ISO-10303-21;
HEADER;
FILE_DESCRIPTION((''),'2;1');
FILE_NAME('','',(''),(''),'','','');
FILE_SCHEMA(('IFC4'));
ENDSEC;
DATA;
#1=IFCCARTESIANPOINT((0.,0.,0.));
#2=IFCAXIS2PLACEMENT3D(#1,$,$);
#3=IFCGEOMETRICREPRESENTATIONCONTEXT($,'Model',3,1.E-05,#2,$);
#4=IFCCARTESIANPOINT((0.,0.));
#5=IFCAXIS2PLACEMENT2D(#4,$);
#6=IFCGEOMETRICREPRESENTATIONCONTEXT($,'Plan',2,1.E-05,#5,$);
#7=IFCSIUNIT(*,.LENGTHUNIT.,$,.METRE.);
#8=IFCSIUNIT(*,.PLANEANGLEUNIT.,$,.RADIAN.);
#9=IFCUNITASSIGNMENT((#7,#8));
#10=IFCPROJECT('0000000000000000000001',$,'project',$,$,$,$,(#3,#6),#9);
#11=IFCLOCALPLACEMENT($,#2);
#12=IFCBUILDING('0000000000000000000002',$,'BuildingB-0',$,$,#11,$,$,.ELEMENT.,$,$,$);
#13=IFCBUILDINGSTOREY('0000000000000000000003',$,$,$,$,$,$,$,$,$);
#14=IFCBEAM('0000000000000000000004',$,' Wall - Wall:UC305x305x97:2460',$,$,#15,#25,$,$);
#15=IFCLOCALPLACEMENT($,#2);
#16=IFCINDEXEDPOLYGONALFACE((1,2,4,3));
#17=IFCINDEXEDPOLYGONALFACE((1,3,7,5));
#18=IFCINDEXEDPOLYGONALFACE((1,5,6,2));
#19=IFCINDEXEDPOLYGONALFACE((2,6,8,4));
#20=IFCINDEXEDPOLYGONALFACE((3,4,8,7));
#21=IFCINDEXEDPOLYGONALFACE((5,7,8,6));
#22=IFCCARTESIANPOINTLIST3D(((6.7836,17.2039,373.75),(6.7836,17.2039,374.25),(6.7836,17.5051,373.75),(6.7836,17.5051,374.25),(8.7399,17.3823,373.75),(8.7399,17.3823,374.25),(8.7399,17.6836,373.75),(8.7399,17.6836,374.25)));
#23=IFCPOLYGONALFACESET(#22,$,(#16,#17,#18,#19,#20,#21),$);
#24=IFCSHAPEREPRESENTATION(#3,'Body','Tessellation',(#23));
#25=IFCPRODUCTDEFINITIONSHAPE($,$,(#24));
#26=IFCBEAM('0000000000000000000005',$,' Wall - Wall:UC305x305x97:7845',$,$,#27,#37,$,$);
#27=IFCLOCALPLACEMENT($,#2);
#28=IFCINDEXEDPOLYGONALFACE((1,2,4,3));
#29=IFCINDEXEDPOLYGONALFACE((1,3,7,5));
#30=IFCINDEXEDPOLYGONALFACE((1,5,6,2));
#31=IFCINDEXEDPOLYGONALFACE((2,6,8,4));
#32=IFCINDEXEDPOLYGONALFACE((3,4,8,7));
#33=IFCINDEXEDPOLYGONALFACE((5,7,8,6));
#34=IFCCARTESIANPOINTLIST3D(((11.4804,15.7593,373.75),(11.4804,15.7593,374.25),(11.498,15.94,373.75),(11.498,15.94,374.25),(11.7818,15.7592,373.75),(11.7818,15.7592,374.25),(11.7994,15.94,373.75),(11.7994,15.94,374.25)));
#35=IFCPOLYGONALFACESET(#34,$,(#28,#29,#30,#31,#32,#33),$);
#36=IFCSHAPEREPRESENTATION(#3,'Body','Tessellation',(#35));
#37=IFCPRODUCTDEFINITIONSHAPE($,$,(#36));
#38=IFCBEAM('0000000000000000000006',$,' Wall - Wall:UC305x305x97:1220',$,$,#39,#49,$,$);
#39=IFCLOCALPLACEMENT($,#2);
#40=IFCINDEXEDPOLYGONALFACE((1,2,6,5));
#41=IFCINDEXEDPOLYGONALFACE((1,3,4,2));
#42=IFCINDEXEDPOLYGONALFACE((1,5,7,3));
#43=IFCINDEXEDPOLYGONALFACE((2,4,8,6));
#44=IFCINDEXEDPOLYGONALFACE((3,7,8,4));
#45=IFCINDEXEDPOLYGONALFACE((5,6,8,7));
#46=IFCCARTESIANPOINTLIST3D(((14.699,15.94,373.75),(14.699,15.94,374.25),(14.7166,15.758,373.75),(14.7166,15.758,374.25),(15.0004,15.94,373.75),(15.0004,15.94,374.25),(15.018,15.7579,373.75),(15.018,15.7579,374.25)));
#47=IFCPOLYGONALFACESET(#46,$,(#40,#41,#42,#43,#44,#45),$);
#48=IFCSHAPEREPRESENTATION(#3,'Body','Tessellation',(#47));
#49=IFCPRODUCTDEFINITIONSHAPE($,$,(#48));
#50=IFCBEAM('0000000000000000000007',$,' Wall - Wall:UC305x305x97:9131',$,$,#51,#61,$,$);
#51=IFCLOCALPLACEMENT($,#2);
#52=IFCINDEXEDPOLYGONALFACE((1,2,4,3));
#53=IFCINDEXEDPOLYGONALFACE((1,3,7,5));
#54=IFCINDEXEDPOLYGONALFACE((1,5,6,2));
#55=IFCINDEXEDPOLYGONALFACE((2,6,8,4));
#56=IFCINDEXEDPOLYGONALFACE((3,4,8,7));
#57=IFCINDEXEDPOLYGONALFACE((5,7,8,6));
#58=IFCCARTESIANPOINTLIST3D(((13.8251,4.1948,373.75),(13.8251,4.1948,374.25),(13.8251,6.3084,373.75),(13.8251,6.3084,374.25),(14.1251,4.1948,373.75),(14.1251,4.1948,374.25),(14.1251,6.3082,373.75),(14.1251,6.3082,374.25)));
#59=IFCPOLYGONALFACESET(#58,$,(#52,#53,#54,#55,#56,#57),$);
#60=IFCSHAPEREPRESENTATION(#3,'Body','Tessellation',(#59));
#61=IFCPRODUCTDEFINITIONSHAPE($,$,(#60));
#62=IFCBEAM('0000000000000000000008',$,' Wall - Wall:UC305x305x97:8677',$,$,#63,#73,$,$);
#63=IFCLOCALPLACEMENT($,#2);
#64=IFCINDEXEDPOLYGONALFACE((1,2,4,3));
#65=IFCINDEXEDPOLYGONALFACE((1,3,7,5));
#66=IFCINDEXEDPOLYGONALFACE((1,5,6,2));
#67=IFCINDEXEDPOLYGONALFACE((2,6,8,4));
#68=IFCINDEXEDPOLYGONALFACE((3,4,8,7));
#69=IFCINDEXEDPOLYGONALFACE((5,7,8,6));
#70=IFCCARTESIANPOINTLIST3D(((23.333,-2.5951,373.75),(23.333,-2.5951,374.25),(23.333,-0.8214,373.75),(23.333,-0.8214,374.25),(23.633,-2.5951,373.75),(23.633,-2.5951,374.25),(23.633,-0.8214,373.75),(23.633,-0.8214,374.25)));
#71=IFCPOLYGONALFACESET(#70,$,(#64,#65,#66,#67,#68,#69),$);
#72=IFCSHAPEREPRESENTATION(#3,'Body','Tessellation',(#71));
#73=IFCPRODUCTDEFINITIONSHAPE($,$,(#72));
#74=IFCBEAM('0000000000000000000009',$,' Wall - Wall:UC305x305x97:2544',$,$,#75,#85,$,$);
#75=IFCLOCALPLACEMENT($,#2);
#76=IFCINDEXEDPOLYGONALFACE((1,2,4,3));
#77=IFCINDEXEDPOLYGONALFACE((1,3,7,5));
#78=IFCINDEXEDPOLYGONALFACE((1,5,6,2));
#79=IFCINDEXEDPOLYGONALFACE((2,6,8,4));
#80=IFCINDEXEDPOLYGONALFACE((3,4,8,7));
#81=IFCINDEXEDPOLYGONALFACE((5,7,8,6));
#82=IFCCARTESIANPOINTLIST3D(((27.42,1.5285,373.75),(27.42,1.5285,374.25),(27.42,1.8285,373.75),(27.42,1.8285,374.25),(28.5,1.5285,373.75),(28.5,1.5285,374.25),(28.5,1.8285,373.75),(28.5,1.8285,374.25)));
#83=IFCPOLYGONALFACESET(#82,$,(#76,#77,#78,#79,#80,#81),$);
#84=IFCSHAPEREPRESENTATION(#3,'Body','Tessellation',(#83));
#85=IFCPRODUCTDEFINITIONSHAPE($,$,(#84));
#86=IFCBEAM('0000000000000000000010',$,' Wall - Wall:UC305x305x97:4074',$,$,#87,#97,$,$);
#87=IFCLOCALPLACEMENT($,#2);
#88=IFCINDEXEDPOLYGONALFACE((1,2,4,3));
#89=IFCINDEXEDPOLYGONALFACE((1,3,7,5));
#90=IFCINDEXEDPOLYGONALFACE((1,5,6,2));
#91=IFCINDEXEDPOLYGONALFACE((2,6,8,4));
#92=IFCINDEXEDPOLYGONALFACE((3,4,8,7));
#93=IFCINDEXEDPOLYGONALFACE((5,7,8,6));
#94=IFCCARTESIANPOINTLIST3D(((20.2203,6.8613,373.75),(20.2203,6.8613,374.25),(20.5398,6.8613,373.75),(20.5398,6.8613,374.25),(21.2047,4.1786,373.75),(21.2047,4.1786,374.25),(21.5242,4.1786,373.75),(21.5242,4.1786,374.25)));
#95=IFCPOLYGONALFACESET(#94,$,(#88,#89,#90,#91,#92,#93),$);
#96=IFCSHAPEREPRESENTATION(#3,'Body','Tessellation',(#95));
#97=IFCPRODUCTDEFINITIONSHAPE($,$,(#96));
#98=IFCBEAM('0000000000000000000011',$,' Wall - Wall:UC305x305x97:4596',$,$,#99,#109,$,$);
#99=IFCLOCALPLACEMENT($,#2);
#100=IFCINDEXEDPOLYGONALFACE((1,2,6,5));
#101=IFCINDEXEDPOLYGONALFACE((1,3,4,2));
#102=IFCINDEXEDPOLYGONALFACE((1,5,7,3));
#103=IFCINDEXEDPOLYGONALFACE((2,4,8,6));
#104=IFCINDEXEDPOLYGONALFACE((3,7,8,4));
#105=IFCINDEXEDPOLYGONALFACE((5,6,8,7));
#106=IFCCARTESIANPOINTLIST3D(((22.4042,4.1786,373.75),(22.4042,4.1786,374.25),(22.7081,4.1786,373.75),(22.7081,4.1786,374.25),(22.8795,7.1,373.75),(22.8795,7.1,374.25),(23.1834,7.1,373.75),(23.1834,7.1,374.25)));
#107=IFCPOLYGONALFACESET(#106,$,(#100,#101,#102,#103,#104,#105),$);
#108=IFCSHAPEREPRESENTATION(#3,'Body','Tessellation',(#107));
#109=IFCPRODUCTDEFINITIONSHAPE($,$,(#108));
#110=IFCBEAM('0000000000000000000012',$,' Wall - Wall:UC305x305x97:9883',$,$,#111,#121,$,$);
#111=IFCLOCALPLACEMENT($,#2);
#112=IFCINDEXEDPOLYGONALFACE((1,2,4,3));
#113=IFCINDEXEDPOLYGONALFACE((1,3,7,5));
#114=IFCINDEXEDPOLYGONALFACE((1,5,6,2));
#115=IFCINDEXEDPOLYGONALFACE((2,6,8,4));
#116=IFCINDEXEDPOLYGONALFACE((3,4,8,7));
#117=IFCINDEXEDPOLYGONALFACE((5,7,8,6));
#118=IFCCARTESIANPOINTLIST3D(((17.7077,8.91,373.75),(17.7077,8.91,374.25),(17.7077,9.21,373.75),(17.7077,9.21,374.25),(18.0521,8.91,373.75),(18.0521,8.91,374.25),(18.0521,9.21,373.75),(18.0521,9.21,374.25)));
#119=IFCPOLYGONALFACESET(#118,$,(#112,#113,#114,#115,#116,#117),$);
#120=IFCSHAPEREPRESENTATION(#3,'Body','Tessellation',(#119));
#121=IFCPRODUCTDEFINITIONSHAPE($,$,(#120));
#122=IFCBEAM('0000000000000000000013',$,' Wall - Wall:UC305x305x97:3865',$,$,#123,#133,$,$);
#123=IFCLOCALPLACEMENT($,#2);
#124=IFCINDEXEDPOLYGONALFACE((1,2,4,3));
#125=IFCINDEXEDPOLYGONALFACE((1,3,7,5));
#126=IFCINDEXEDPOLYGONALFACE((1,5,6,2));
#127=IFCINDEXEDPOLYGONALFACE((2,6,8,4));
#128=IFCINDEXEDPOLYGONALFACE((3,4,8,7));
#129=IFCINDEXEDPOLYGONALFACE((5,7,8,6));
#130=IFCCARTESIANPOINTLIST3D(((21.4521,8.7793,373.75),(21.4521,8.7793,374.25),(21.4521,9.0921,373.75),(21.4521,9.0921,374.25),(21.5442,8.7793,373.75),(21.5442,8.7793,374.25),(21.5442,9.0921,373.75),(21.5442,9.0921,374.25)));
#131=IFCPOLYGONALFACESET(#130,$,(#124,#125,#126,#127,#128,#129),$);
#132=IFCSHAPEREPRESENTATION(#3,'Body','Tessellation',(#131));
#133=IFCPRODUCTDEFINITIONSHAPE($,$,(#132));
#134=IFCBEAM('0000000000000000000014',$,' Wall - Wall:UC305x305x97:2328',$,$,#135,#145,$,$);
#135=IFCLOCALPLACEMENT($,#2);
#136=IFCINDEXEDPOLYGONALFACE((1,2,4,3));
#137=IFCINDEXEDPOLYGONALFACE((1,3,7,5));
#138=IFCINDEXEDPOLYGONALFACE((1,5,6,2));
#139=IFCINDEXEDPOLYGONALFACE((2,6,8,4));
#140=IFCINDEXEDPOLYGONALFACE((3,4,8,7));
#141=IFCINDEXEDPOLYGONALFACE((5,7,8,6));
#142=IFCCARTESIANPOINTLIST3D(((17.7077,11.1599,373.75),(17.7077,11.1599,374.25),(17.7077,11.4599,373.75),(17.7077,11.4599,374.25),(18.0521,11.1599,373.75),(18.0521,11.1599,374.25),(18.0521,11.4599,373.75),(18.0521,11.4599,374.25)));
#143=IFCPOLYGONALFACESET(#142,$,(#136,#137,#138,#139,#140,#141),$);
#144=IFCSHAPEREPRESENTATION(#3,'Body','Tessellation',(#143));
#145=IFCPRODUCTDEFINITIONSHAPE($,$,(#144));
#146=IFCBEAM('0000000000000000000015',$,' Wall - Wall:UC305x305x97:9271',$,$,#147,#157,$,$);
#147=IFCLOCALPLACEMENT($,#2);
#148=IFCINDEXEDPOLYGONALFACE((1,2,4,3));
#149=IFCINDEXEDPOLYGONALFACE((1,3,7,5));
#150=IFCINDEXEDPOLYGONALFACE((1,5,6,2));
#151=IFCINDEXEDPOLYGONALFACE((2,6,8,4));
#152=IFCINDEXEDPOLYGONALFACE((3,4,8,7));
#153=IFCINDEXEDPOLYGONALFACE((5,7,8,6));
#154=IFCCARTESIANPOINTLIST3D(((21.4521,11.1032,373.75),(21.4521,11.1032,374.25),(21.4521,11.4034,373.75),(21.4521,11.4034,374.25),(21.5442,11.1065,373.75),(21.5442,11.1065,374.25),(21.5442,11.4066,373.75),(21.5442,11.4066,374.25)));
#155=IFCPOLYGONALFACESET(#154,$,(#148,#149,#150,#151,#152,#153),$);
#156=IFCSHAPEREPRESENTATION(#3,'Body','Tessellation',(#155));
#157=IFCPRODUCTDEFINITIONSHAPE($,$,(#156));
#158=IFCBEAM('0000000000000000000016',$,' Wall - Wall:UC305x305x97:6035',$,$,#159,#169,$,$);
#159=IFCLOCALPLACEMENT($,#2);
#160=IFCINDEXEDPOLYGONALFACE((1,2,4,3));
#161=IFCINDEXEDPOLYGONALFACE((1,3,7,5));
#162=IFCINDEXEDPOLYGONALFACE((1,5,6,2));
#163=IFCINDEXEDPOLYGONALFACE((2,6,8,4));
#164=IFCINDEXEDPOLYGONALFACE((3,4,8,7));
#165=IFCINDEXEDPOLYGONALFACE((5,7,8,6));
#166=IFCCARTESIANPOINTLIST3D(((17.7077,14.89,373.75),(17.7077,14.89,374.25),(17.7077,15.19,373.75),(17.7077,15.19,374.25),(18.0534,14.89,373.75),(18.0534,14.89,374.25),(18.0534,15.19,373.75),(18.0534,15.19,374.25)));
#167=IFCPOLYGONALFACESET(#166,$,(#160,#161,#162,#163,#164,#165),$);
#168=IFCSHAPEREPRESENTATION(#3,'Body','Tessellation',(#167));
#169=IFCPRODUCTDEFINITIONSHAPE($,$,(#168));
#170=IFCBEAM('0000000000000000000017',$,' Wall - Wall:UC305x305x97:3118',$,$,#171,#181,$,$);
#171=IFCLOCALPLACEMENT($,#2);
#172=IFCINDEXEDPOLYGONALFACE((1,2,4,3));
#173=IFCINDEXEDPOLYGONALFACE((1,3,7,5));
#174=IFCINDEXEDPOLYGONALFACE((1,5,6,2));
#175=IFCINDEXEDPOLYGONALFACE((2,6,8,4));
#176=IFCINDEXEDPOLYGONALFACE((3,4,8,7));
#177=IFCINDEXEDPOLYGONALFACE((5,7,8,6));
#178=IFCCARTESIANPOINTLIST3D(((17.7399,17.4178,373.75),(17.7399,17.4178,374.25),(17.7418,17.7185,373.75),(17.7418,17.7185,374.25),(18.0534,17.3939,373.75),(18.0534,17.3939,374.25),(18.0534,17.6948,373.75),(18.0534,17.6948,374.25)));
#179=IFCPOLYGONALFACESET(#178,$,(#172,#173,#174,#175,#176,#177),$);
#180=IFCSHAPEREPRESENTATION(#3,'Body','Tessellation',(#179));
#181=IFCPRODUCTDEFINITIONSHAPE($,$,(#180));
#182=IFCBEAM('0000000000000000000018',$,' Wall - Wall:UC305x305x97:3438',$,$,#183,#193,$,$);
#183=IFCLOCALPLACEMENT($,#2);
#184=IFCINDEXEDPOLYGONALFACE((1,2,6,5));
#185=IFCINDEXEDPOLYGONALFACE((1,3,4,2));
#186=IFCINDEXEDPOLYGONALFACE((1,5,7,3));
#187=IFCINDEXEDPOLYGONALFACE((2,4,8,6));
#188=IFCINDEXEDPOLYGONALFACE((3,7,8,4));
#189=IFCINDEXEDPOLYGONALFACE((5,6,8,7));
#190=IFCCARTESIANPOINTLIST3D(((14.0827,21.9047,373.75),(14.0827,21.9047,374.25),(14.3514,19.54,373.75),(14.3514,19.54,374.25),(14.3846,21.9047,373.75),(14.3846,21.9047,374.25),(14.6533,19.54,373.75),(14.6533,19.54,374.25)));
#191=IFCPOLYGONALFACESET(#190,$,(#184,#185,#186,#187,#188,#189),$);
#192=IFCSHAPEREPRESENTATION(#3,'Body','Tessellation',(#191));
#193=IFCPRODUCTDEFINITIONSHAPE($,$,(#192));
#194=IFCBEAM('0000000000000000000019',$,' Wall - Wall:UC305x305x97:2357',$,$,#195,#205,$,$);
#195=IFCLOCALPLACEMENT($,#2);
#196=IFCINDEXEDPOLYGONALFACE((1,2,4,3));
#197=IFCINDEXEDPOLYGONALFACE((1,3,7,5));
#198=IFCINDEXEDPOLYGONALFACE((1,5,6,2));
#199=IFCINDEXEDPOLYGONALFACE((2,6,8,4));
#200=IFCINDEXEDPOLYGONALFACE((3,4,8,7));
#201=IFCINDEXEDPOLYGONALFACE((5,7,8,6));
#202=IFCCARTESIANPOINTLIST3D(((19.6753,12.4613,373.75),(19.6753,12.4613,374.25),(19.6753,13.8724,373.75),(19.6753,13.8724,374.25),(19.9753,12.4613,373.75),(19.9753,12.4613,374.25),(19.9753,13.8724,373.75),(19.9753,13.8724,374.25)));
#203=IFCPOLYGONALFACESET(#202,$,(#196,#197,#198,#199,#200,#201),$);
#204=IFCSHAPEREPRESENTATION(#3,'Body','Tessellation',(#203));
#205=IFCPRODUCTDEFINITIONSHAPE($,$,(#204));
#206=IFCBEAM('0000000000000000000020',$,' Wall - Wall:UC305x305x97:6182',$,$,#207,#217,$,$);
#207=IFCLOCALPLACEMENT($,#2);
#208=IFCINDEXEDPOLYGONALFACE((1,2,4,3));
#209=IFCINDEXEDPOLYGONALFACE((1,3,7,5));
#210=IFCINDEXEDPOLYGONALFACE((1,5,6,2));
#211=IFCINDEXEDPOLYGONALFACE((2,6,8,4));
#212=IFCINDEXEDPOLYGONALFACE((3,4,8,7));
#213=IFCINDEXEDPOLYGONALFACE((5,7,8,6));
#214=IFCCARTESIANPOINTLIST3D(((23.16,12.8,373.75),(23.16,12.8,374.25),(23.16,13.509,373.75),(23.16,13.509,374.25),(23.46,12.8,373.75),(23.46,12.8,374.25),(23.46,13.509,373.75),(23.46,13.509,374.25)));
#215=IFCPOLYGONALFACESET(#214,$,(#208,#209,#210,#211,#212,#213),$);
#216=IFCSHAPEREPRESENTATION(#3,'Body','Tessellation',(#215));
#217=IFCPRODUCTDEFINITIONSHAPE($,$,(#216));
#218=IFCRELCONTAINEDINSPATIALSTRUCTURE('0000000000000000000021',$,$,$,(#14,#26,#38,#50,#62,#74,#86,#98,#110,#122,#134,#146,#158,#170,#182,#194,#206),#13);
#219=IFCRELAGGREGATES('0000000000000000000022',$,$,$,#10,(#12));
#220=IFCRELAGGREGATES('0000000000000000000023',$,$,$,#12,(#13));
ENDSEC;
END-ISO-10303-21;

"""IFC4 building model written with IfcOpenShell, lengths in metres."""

from ifc_helpers import new_model, si_unit, origin, origin_2d, place, context, project, spatial, polyline, outline, extrude, element, save


model = new_model("IFC4")

# Units and contexts
model_context = context("Model", 3, precision=1e-05, world=origin())
plan_context = context("Plan", 2, precision=1e-05, world=origin_2d())
ifc_project = project(units=[si_unit("LENGTHUNIT", "METRE"), si_unit("PLANEANGLEUNIT", "RADIAN")], contexts=[model_context, plan_context])

# Building, storey
building_placement = place(None, origin())
building = spatial("IfcBuilding", under=ifc_project, at=building_placement, Name="BuildingB-0", CompositionType="ELEMENT")
storey = spatial("IfcBuildingStorey", under=building)

# Beams
element("IfcBeam", 1, inside=storey, Name=" Wall - Wall:UC305x305x97:2460", context=model_context, shape_type="SweptSolid", body=[
    extrude(outline(polyline([(6.7836, 17.2039, 373.75), (6.7836, 17.5051, 373.75), (8.7399, 17.6836, 373.75), (8.7399, 17.3823, 373.75), (6.7836, 17.2039, 373.75)])), None, (0.0, 0.0, 1.0), 0.5),
])
element("IfcBeam", 2, inside=storey, Name=" Wall - Wall:UC305x305x97:7845", context=model_context, shape_type="SweptSolid", body=[
    extrude(outline(polyline([(11.4804, 15.7593, 373.75), (11.498, 15.94, 373.75), (11.7994, 15.94, 373.75), (11.7818, 15.7592, 373.75), (11.4804, 15.7593, 373.75)])), None, (0.0, 0.0, 1.0), 0.5),
])
element("IfcBeam", 3, inside=storey, Name=" Wall - Wall:UC305x305x97:1220", context=model_context, shape_type="SweptSolid", body=[
    extrude(outline(polyline([(14.7166, 15.758, 373.75), (14.699, 15.94, 373.75), (15.0004, 15.94, 373.75), (15.018, 15.7579, 373.75), (14.7166, 15.758, 373.75)])), None, (0.0, 0.0, 1.0), 0.5),
])
element("IfcBeam", 4, inside=storey, Name=" Wall - Wall:UC305x305x97:9131", context=model_context, shape_type="SweptSolid", body=[
    extrude(outline(polyline([(13.8251, 4.1948, 373.75), (13.8251, 6.3084, 373.75), (14.1251, 6.3082, 373.75), (14.1251, 4.1948, 373.75), (13.8251, 4.1948, 373.75)])), None, (0.0, 0.0, 1.0), 0.5),
])
element("IfcBeam", 5, inside=storey, Name=" Wall - Wall:UC305x305x97:8677", context=model_context, shape_type="SweptSolid", body=[
    extrude(outline(polyline([(23.333, -2.5951, 373.75), (23.333, -0.8214, 373.75), (23.633, -0.8214, 373.75), (23.633, -2.5951, 373.75), (23.333, -2.5951, 373.75)])), None, (0.0, 0.0, 1.0), 0.5),
])
element("IfcBeam", 6, inside=storey, Name=" Wall - Wall:UC305x305x97:2544", context=model_context, shape_type="SweptSolid", body=[
    extrude(outline(polyline([(27.42, 1.5285, 373.75), (27.42, 1.8285, 373.75), (28.5, 1.8285, 373.75), (28.5, 1.5285, 373.75), (27.42, 1.5285, 373.75)])), None, (0.0, 0.0, 1.0), 0.5),
])
element("IfcBeam", 7, inside=storey, Name=" Wall - Wall:UC305x305x97:4074", context=model_context, shape_type="SweptSolid", body=[
    extrude(outline(polyline([(21.2047, 4.1786, 373.75), (21.5242, 4.1786, 373.75), (20.5398, 6.8613, 373.75), (20.2203, 6.8613, 373.75), (21.2047, 4.1786, 373.75)])), None, (0.0, 0.0, 1.0), 0.5),
])
element("IfcBeam", 8, inside=storey, Name=" Wall - Wall:UC305x305x97:4596", context=model_context, shape_type="SweptSolid", body=[
    extrude(outline(polyline([(22.4042, 4.1786, 373.75), (22.7081, 4.1786, 373.75), (23.1834, 7.1, 373.75), (22.8795, 7.1, 373.75), (22.4042, 4.1786, 373.75)])), None, (0.0, 0.0, 1.0), 0.5),
])
element("IfcBeam", 9, inside=storey, Name=" Wall - Wall:UC305x305x97:9883", context=model_context, shape_type="SweptSolid", body=[
    extrude(outline(polyline([(17.7077, 8.91, 373.75), (17.7077, 9.21, 373.75), (18.0521, 9.21, 373.75), (18.0521, 8.91, 373.75), (17.7077, 8.91, 373.75)])), None, (0.0, 0.0, 1.0), 0.5),
])
element("IfcBeam", 10, inside=storey, Name=" Wall - Wall:UC305x305x97:3865", context=model_context, shape_type="SweptSolid", body=[
    extrude(outline(polyline([(21.4521, 8.7793, 373.75), (21.5442, 8.7793, 373.75), (21.5442, 9.0921, 373.75), (21.4521, 9.0921, 373.75), (21.4521, 8.7793, 373.75)])), None, (0.0, 0.0, 1.0), 0.5),
])
element("IfcBeam", 11, inside=storey, Name=" Wall - Wall:UC305x305x97:2328", context=model_context, shape_type="SweptSolid", body=[
    extrude(outline(polyline([(17.7077, 11.1599, 373.75), (18.0521, 11.1599, 373.75), (18.0521, 11.4599, 373.75), (17.7077, 11.4599, 373.75), (17.7077, 11.1599, 373.75)])), None, (0.0, 0.0, 1.0), 0.5),
])
element("IfcBeam", 12, inside=storey, Name=" Wall - Wall:UC305x305x97:9271", context=model_context, shape_type="SweptSolid", body=[
    extrude(outline(polyline([(21.4521, 11.1032, 373.75), (21.5442, 11.1065, 373.75), (21.5442, 11.4066, 373.75), (21.4521, 11.4034, 373.75), (21.4521, 11.1032, 373.75)])), None, (0.0, 0.0, 1.0), 0.5),
])
element("IfcBeam", 13, inside=storey, Name=" Wall - Wall:UC305x305x97:6035", context=model_context, shape_type="SweptSolid", body=[
    extrude(outline(polyline([(17.7077, 15.19, 373.75), (18.0534, 15.19, 373.75), (18.0534, 14.89, 373.75), (17.7077, 14.89, 373.75), (17.7077, 15.19, 373.75)])), None, (0.0, 0.0, 1.0), 0.5),
])
element("IfcBeam", 14, inside=storey, Name=" Wall - Wall:UC305x305x97:3118", context=model_context, shape_type="SweptSolid", body=[
    extrude(outline(polyline([(17.7399, 17.4178, 373.75), (18.0534, 17.3939, 373.75), (18.0534, 17.6948, 373.75), (17.7418, 17.7185, 373.75), (17.7399, 17.4178, 373.75)])), None, (0.0, 0.0, 1.0), 0.5),
])
element("IfcBeam", 15, inside=storey, Name=" Wall - Wall:UC305x305x97:3438", context=model_context, shape_type="SweptSolid", body=[
    extrude(outline(polyline([(14.3514, 19.54, 373.75), (14.6533, 19.54, 373.75), (14.3846, 21.9047, 373.75), (14.0827, 21.9047, 373.75), (14.3514, 19.54, 373.75)])), None, (0.0, 0.0, 1.0), 0.5),
])
element("IfcBeam", 16, inside=storey, Name=" Wall - Wall:UC305x305x97:2357", context=model_context, shape_type="SweptSolid", body=[
    extrude(outline(polyline([(19.6753, 12.4613, 373.75), (19.9753, 12.4613, 373.75), (19.9753, 13.8724, 373.75), (19.6753, 13.8724, 373.75), (19.6753, 12.4613, 373.75)])), None, (0.0, 0.0, 1.0), 0.5),
])
element("IfcBeam", 17, inside=storey, Name=" Wall - Wall:UC305x305x97:6182", context=model_context, shape_type="SweptSolid", body=[
    extrude(outline(polyline([(23.16, 12.8, 373.75), (23.46, 12.8, 373.75), (23.46, 13.509, 373.75), (23.16, 13.509, 373.75), (23.16, 12.8, 373.75)])), None, (0.0, 0.0, 1.0), 0.5),
])

save(model, "model.ifc")
